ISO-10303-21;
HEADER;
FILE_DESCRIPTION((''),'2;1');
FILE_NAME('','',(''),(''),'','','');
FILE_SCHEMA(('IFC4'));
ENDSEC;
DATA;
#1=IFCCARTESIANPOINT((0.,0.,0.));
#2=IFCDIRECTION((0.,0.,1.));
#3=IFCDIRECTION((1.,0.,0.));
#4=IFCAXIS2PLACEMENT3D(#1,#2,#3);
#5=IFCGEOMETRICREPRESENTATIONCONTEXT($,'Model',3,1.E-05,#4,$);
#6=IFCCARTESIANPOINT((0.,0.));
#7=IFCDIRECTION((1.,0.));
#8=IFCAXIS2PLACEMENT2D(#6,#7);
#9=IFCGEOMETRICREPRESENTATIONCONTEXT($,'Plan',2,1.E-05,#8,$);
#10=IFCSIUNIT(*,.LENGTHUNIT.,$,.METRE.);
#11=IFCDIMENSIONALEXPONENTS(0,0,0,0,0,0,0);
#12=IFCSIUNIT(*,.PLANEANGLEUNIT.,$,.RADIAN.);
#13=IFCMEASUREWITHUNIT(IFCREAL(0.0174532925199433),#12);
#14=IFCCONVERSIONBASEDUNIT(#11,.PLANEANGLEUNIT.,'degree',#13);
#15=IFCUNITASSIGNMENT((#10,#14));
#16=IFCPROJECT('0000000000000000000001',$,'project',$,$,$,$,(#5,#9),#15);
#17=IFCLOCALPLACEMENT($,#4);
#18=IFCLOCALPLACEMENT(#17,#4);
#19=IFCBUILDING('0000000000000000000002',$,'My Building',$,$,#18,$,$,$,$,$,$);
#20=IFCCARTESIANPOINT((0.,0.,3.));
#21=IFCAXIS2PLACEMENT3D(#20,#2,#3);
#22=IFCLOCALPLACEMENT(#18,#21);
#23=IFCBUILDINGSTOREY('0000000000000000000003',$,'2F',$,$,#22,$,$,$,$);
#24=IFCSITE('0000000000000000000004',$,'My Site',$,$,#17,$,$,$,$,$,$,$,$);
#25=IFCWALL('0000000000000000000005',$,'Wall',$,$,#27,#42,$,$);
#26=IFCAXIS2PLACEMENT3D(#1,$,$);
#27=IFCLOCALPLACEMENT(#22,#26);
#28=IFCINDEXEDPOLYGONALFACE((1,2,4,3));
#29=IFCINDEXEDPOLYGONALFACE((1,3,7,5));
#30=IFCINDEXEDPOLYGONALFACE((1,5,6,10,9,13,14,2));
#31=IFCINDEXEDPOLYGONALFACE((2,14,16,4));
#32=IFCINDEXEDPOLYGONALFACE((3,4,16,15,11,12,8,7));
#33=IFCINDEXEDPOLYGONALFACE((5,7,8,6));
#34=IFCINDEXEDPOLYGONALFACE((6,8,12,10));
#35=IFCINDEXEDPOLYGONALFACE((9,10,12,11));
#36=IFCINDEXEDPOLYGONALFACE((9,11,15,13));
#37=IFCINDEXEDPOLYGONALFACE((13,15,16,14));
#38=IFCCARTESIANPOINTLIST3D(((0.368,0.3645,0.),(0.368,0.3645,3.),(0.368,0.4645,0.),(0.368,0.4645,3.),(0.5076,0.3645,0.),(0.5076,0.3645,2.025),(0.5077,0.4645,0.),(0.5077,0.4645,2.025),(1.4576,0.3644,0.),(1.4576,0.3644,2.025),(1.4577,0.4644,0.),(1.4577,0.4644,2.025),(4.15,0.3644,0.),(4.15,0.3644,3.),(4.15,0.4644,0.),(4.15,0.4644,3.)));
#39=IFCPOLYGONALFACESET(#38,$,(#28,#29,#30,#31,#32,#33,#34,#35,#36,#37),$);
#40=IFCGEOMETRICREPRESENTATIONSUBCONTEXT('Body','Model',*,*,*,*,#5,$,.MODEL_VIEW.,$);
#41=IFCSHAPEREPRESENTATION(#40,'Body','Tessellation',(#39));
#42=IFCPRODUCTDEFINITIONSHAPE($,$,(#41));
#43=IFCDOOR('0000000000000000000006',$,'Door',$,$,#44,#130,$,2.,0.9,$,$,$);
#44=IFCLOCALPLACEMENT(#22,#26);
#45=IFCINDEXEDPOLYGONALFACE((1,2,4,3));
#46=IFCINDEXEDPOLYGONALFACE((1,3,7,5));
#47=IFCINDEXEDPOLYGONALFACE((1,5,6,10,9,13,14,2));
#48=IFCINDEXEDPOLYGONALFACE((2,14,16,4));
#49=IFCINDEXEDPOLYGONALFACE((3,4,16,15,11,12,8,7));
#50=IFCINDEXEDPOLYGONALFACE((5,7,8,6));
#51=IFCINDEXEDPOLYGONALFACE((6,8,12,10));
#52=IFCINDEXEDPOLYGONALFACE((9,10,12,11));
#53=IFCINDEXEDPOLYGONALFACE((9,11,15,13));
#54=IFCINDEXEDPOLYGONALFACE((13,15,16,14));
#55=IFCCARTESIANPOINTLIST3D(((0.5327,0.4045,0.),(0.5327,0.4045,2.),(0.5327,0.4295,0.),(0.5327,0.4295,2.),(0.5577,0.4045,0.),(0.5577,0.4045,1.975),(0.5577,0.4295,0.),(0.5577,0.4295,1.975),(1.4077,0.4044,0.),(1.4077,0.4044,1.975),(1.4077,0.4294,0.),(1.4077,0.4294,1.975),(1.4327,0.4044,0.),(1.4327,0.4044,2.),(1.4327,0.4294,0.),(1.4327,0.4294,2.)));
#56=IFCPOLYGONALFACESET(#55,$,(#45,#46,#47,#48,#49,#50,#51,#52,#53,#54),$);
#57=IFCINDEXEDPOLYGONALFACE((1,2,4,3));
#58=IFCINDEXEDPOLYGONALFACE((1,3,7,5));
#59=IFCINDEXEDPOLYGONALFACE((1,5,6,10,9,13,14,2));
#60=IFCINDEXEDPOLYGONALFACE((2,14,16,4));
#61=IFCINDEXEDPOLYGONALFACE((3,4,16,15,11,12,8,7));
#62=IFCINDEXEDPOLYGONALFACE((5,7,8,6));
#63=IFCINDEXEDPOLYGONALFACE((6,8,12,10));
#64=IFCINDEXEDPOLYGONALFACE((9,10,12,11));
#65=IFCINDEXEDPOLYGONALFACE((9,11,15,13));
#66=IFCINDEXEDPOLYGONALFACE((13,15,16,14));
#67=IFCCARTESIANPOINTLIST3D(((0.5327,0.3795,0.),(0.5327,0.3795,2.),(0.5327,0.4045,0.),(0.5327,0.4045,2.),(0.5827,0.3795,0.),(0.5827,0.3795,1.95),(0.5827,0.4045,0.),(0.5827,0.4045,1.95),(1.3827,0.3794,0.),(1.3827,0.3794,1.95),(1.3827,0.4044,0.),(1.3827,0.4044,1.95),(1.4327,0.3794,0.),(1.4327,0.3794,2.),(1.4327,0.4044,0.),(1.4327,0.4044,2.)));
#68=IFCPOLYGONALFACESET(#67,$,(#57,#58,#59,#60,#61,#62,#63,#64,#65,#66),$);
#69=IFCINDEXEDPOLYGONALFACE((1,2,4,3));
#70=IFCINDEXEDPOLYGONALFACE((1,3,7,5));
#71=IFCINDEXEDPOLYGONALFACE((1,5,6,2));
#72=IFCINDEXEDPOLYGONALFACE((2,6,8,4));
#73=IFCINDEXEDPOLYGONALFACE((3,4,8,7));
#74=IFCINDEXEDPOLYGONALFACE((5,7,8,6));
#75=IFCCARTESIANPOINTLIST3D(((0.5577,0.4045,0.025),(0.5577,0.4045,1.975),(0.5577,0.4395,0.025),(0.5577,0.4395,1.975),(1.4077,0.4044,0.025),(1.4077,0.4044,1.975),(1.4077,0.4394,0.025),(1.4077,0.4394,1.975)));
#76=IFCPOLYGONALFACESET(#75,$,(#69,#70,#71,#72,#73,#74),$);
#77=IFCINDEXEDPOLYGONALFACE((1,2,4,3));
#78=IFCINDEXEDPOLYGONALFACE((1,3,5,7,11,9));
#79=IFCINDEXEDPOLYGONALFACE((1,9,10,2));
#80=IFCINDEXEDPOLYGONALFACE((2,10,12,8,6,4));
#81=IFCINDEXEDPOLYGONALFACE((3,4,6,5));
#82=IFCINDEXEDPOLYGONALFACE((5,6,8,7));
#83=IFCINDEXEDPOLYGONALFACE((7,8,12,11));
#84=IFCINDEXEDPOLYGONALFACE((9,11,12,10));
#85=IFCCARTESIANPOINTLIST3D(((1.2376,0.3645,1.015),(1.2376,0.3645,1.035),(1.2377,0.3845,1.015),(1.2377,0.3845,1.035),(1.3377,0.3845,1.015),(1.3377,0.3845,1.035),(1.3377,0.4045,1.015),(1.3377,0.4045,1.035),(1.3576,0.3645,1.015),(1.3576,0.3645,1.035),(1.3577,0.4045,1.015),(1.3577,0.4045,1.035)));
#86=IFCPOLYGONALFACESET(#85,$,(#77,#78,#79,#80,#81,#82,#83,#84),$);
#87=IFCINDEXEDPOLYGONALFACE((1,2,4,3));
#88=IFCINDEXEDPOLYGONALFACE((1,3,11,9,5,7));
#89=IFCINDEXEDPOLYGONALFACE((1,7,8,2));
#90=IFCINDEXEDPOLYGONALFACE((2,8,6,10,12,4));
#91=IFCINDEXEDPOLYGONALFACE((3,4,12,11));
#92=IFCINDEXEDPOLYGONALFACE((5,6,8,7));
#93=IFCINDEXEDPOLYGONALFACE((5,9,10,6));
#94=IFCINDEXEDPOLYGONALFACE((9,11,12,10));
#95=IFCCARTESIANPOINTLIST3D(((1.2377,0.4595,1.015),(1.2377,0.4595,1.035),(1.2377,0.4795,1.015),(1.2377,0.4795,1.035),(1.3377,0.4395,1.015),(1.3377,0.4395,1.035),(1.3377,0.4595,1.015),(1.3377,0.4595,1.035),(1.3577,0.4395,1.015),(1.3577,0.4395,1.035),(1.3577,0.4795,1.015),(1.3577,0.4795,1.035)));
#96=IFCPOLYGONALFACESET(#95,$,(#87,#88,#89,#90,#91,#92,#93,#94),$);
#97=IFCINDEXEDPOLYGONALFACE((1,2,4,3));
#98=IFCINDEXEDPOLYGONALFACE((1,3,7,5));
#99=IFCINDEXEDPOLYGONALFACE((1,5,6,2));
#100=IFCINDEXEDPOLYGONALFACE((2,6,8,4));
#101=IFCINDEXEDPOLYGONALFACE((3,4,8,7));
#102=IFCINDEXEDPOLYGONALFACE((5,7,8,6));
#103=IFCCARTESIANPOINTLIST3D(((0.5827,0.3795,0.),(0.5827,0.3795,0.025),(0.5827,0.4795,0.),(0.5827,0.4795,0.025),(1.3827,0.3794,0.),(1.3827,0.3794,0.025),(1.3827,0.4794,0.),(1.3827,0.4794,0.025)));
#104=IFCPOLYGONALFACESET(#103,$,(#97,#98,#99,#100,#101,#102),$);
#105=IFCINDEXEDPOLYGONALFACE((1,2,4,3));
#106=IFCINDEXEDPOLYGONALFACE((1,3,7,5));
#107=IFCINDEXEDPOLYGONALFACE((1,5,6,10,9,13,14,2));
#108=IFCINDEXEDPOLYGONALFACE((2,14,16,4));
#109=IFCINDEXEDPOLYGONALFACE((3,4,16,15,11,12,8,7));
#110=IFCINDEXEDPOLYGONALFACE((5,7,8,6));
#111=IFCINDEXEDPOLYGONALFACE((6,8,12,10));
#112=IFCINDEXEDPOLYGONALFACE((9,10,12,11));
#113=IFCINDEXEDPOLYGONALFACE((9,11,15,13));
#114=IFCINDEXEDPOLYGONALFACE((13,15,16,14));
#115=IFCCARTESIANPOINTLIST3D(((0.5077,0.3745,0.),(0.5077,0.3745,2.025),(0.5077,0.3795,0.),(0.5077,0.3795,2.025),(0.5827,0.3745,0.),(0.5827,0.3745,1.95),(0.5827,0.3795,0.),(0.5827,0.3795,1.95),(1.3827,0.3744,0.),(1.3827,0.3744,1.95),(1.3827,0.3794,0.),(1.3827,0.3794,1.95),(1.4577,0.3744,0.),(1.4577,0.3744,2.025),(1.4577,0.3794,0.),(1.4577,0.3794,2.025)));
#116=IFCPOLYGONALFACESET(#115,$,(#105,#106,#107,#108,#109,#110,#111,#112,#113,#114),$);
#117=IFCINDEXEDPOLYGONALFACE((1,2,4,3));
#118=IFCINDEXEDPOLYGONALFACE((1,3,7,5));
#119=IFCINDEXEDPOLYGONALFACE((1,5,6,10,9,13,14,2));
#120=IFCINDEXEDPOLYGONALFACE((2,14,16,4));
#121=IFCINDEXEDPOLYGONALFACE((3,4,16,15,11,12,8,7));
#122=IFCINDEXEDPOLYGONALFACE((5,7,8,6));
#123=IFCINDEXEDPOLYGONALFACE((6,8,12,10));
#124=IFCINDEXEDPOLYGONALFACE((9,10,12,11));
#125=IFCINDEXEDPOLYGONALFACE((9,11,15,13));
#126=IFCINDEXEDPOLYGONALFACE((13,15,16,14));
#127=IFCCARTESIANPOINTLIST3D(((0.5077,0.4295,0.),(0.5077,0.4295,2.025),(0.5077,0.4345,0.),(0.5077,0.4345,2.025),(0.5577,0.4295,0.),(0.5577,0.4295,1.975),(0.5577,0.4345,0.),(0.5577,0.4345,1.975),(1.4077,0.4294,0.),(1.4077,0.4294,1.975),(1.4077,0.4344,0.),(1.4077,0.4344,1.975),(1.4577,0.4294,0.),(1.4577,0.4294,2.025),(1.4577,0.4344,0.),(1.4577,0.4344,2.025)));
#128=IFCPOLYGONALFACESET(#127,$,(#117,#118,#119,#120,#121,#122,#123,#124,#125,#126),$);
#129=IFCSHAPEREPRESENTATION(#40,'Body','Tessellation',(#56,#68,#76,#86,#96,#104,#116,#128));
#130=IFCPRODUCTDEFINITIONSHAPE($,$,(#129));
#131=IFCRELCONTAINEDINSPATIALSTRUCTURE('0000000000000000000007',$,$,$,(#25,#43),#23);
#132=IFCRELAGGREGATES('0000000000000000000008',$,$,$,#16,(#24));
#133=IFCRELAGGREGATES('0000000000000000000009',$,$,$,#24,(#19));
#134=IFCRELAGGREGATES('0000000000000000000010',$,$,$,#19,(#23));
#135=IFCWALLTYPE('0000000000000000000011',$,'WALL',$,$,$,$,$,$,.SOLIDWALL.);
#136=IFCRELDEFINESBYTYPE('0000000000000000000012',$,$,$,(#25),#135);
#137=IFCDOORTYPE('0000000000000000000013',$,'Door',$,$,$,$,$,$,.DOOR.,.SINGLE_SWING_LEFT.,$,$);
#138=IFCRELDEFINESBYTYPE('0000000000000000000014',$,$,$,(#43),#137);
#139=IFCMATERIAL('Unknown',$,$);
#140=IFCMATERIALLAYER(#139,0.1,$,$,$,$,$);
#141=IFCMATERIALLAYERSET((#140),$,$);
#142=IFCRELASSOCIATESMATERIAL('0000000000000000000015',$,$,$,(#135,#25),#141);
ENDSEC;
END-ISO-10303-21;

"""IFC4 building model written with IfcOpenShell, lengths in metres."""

from ifc_helpers import new_model, entity, si_unit, converted_unit, frame, origin_with_axes, origin_2d_with_axis, place, context, subcontext, project, spatial, line, indexed_curve, outline, extrude, shape, source, transform, mapped, material, layer, layer_set, layer_usage, type_object, type_shapes, element, fill, save


model = new_model("IFC4")

# Units and contexts
model_context = context("Model", 3, precision=1e-05, world=origin_with_axes())
plan_context = context("Plan", 2, precision=1e-05, world=origin_2d_with_axis())
body_context_1 = subcontext(model_context, "Body", "Model", "MODEL_VIEW")
body_context_2 = subcontext(plan_context, "Body", "Plan", "PLAN_VIEW")
ifc_project = project(units=[si_unit("LENGTHUNIT", "METRE"), converted_unit("PLANEANGLEUNIT", "degree", entity("IfcReal", 0.0174532925199433), si_unit("PLANEANGLEUNIT", "RADIAN"), dimensions=[0, 0, 0, 0, 0, 0, 0])], contexts=[model_context, plan_context])

# Site, building, storey
site_placement = place(None, origin_with_axes())
site = spatial("IfcSite", under=ifc_project, at=site_placement, Name="My Site")
building_placement = place(site_placement, origin_with_axes())
building = spatial("IfcBuilding", under=site, at=building_placement, Name="My Building")
storey_placement = place(building_placement, frame((0.0, 0.0, 3.0), z_axis=(0.0, 0.0, 1.0), x_axis=(1.0, 0.0, 0.0)))
storey = spatial("IfcBuildingStorey", under=building, at=storey_placement, Name="2F")

# Shared definitions
ifc_material = material(Name="Unknown")

# Shared definitions
ifc_layer_1 = layer(ifc_material, 0.1)
ifc_layer_set_1 = layer_set([ifc_layer_1])
wall_type = type_object("IfcWallType", Name="WALL", PredefinedType="SOLIDWALL", material=ifc_layer_set_1)

# Shared definitions
shared_shape_1 = source(origin_with_axes(), body_context_1, "Body", "SweptSolid", [
    extrude(outline(indexed_curve([(0.0, 0.0), (0.9, 0.0), (0.9, 2.0), (0.0, 2.0)], segments=[line(1, 2, 3, 4, 1)])), frame((0.0, -0.6, 0.0), z_axis=(0.0, -1.0, 0.0), x_axis=(1.0, 0.0, 0.0)), (0.0, 0.0, -1.0), 1.2),
])
door_type = type_object("IfcDoorType", Name="Door", OperationType="SINGLE_SWING_LEFT", PredefinedType="DOOR")
shared_shape_2 = source(origin_with_axes(), body_context_1, "Body", "SweptSolid", [
    extrude(outline(indexed_curve([(0.0, 0.0), (0.0, 2.0), (0.9, 2.0), (0.9, 0.0), (0.875, 0.0), (0.875, 1.975), (0.025, 1.975), (0.025, 0.0)], segments=[line(1, 2, 3, 4, 5, 6, 7, 8, 1)])), frame((0.0, 0.025, 0.0), z_axis=(0.0, -1.0, 0.0), x_axis=(1.0, 0.0, 0.0)), (0.0, 0.0, -1.0), 0.025),
    extrude(outline(indexed_curve([(0.0, 0.0), (0.0, 2.0), (0.9, 2.0), (0.9, 0.0), (0.85, 0.0), (0.85, 1.95), (0.05, 1.95), (0.05, 0.0)], segments=[line(1, 2, 3, 4, 5, 6, 7, 8, 1)])), frame((0.0, 0.0, 0.0), z_axis=(0.0, -1.0, 0.0), x_axis=(1.0, 0.0, 0.0)), (0.0, 0.0, -1.0), 0.025),
    extrude(outline(indexed_curve([(0.0, 0.0), (0.85, 0.0), (0.85, 0.035), (0.0, 0.035)], segments=[line(1, 2, 3, 4, 1)])), frame((0.025, 0.025, 0.025), z_axis=(0.0, 0.0, 1.0), x_axis=(1.0, 0.0, 0.0)), (0.0, 0.0, 1.0), 1.95),
    extrude(outline(indexed_curve([(0.0, 0.0), (0.0, -0.04), (-0.12, -0.04), (-0.12, -0.02), (-0.02, -0.02), (-0.02, 0.0)], segments=[line(1, 2, 3, 4, 5, 6, 1)])), frame((0.825, 0.025, 1.015), z_axis=(0.0, 0.0, 1.0), x_axis=(1.0, 0.0, 0.0)), (0.0, 0.0, 1.0), 0.02),
    extrude(outline(indexed_curve([(0.0, 0.0), (0.0, 0.04), (-0.12, 0.04), (-0.12, 0.02), (-0.02, 0.02), (-0.02, 0.0)], segments=[line(1, 2, 3, 4, 5, 6, 1)])), frame((0.825, 0.06, 1.015), z_axis=(0.0, 0.0, 1.0), x_axis=(1.0, 0.0, 0.0)), (0.0, 0.0, 1.0), 0.02),
    extrude(outline(indexed_curve([(0.0, 0.0), (0.8, 0.0), (0.8, 0.1), (0.0, 0.1)], segments=[line(1, 2, 3, 4, 1)])), frame((0.05, 0.0, 0.0), z_axis=(0.0, 0.0, 1.0), x_axis=(1.0, 0.0, 0.0)), (0.0, 0.0, 1.0), 0.025),
    extrude(outline(indexed_curve([(0.0, 0.0), (0.0, 2.025), (0.95, 2.025), (0.95, 0.0), (0.875, 0.0), (0.875, 1.95), (0.075, 1.95), (0.075, 0.0)], segments=[line(1, 2, 3, 4, 5, 6, 7, 8, 1)])), frame((-0.025, -0.005, 0.0), z_axis=(0.0, -1.0, 0.0), x_axis=(1.0, 0.0, 0.0)), (0.0, 0.0, -1.0), 0.005),
    extrude(outline(indexed_curve([(0.0, 0.0), (0.0, 2.025), (0.95, 2.025), (0.95, 0.0), (0.9, 0.0), (0.9, 1.975), (0.05, 1.975), (0.05, 0.0)], segments=[line(1, 2, 3, 4, 5, 6, 7, 8, 1)])), frame((-0.025, 0.05, 0.0), z_axis=(0.0, -1.0, 0.0), x_axis=(1.0, 0.0, 0.0)), (0.0, 0.0, -1.0), 0.005),
])
shared_shape_3 = source(origin_with_axes(), body_context_2, "Body", "Curve2D", [
    entity("IfcIndexedPolyCurve", entity("IfcCartesianPointList2D", [[0.0, 0.0], [0.0, 0.05], [0.025, 0.05], [0.025, 0.025], [0.05, 0.025], [0.05, 0.0]]), [entity("IfcLineIndex", [1, 2, 3, 4, 5, 6, 1])]),
    entity("IfcIndexedPolyCurve", entity("IfcCartesianPointList2D", [[0.9, 0.0], [0.9, 0.05], [0.875, 0.05], [0.875, 0.025], [0.85, 0.025], [0.85, 0.0]]), [entity("IfcLineIndex", [1, 2, 3, 4, 5, 6, 1])]),
    entity("IfcTrimmedCurve", entity("IfcEllipse", entity("IfcAxis2Placement2D", entity("IfcCartesianPoint", [0.06, 0.05]), entity("IfcDirection", [1.0, 0.0])), 0.815, 0.85), [entity("IfcCartesianPoint", [0.875, 0.05])], [entity("IfcCartesianPoint", [0.06, 0.9])], True, "CARTESIAN"),
    entity("IfcIndexedPolyCurve", entity("IfcCartesianPointList2D", [[0.025, 0.05], [0.06, 0.05], [0.06, 0.9], [0.025, 0.9]]), [entity("IfcLineIndex", [1, 2, 3, 4, 1])]),
])
type_shapes(door_type, [shared_shape_2, shared_shape_3])

# Wall, openings, door
ifc_layer_usage_1 = layer_usage(ifc_layer_set_1, "AXIS2", "POSITIVE", 0.0)
wall_1_placement = place(storey_placement, frame((4.15, 0.4644, 0.0), z_axis=(0.0, 0.0, 1.0), x_axis=(-1.0, 0.000024, 0.0)))
wall_1 = element("IfcWall", 1, at=wall_1_placement, inside=storey, type_object=wall_type, material=ifc_layer_usage_1, Name="Wall", context=body_context_1, shape_type="SweptSolid", body=[
    extrude(outline(indexed_curve([(0.0, 0.0), (0.0, 0.1), (3.782, 0.1), (3.782, 0.0)], segments=[line(1, 2, 3, 4, 1)])), origin_with_axes(), (0.0, 0.0, 1.0), 3.0),
])
opening_1_placement = place(wall_1_placement, frame((2.7173, 0.0, 0.0), z_axis=(0.0, 0.0, 1.0), x_axis=(1.0, 0.0, 0.0)))
opening_1 = element("IfcOpeningElement", 2, at=opening_1_placement, cuts=wall_1, PredefinedType="OPENING", context=body_context_1, shape_type="MappedRepresentation", body=[
    mapped(shared_shape_1, transform((0.0, 0.0, 0.0), x_axis=(1.0, 0.0, 0.0), y_axis=(0.0, 1.0, 0.0), z_axis=(0.0, 0.0, 1.0), scale=1.0)),
])
shared_shape_4 = source(origin_with_axes(), body_context_1, "Body", "SweptSolid", [
    extrude(outline(indexed_curve([(0.0, 0.0), (0.95, 0.0), (0.95, 2.025), (0.0, 2.025)], segments=[line(1, 2, 3, 4, 1)])), frame((-0.025, -0.6, 0.0), z_axis=(0.0, -1.0, 0.0), x_axis=(1.0, 0.0, 0.0)), (0.0, 0.0, -1.0), 1.2),
])
opening_2_placement = place(wall_1_placement, frame((2.7173, 0.0, 0.0), z_axis=(0.0, 0.0, 1.0), x_axis=(1.0, 0.0, 0.0)))
element("IfcOpeningElement", 3, at=opening_2_placement, cuts=wall_1, PredefinedType="OPENING", context=body_context_1, shape_type="MappedRepresentation", body=[
    mapped(shared_shape_4, transform((0.0, 0.0, 0.0), x_axis=(1.0, 0.0, 0.0), y_axis=(0.0, 1.0, 0.0), z_axis=(0.0, 0.0, 1.0), scale=1.0)),
])
door_1_placement = place(opening_1_placement, frame((0.9, 0.085, 0.0), z_axis=(0.0, 0.0, 1.0), x_axis=(-1.0, 0.0, 0.0)))
door_1 = element("IfcDoor", 4, at=door_1_placement, inside=storey, type_object=door_type, Name="Door", OverallHeight=2.0, OverallWidth=0.9, shapes=[
    shape(body_context_1, "Body", "MappedRepresentation", [mapped(shared_shape_2, transform((0.0, 0.0, 0.0), x_axis=(1.0, 0.0, 0.0), y_axis=(0.0, 1.0, 0.0), z_axis=(0.0, 0.0, 1.0), scale=1.0))]),
    shape(body_context_2, "Body", "MappedRepresentation", [mapped(shared_shape_3, transform((0.0, 0.0, 0.0), x_axis=(1.0, 0.0, 0.0), y_axis=(0.0, 1.0, 0.0), z_axis=(0.0, 0.0, 1.0), scale=1.0))]),
])
fill(opening_1, door_1)

save(model, "model.ifc")
